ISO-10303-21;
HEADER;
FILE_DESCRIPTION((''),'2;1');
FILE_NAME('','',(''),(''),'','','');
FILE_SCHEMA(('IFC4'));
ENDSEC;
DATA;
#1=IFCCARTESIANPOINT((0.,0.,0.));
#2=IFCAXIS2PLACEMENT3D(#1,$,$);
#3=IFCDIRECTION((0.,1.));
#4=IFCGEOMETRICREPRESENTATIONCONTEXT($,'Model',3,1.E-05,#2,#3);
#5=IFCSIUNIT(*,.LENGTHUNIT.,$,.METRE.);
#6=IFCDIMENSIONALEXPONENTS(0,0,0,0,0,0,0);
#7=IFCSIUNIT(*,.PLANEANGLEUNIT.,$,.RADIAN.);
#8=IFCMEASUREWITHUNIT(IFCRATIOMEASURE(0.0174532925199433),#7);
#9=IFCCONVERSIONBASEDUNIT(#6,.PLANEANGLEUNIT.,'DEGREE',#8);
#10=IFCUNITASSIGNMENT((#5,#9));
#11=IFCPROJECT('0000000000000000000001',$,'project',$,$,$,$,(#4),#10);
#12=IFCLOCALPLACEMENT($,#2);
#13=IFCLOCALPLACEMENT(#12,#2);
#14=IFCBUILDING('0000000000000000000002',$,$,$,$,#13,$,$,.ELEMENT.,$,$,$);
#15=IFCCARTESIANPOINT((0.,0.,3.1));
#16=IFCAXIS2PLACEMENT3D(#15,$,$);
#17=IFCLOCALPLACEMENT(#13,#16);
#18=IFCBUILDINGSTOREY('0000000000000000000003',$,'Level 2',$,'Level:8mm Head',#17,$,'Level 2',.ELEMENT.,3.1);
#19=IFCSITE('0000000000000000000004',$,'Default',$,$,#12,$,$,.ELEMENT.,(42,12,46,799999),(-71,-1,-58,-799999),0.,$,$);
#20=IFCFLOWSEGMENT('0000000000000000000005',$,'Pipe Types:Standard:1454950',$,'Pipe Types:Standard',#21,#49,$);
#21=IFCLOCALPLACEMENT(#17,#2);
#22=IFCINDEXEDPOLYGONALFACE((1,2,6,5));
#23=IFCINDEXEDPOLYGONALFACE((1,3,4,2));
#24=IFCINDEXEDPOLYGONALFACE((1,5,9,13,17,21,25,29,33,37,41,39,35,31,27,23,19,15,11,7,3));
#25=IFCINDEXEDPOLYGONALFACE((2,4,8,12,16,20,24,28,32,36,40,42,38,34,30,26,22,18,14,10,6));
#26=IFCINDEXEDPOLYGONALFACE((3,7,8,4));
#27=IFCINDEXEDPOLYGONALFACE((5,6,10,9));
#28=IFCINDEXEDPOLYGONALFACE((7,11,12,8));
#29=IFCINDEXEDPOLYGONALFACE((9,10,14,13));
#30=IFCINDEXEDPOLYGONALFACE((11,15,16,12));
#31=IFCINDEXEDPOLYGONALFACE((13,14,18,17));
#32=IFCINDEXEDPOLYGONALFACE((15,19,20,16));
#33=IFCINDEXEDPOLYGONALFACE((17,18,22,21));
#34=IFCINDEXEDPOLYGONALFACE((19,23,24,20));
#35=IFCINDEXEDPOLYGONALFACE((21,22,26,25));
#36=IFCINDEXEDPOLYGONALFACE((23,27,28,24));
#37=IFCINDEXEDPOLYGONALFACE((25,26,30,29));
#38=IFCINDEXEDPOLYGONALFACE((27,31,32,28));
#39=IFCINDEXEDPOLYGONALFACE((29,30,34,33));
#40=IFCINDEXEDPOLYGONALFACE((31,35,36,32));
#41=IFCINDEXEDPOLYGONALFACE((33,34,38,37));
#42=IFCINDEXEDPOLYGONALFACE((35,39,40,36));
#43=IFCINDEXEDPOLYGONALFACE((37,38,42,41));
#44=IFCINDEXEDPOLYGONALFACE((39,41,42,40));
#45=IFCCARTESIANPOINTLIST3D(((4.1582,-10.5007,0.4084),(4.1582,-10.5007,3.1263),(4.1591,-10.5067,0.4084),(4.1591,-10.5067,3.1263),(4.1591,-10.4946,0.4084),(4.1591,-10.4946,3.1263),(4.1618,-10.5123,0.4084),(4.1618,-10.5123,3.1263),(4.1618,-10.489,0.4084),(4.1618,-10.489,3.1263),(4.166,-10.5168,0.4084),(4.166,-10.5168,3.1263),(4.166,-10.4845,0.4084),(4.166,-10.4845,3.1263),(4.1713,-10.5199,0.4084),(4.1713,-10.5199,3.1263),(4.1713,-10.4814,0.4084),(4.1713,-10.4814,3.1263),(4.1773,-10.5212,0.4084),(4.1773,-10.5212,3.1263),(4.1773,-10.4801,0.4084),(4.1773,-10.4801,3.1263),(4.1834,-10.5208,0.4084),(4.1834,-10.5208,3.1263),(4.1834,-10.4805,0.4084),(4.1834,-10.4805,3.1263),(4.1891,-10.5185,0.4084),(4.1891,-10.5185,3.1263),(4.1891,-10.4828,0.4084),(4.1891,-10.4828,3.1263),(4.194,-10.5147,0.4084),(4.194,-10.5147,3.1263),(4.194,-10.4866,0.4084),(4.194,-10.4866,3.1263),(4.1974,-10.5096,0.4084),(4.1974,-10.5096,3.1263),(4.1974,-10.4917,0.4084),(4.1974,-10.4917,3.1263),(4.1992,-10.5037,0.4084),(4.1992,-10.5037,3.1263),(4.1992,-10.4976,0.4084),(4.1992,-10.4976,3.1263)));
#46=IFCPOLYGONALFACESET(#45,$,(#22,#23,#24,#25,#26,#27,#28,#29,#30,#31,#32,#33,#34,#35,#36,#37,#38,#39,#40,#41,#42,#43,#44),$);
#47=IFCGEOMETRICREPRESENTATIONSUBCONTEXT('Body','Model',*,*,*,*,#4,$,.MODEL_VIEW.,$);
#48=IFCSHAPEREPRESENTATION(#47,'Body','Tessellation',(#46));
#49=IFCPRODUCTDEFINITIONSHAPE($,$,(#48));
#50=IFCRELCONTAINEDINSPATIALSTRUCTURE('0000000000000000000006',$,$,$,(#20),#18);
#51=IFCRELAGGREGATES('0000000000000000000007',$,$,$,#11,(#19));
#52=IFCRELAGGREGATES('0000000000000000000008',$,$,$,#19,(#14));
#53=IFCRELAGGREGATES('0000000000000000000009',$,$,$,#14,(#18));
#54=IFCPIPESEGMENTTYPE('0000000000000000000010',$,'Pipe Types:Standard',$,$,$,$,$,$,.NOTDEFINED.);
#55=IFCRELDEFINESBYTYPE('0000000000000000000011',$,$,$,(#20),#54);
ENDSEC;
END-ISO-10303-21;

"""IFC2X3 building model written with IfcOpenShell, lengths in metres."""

from ifc_helpers import new_model, entity, si_unit, converted_unit, direction, frame, origin, origin_2d_with_axis, place, context, subcontext, project, spatial, circle, extrude, type_object, element, save


model = new_model("IFC2X3")

# Units and contexts
model_context = context("Model", 3, precision=1e-05, world=origin(), true_north=direction((0.0, 1.0)))
body_context = subcontext(model_context, "Body", "Model", "MODEL_VIEW")
ifc_project = project(units=[si_unit("LENGTHUNIT", "METRE"), converted_unit("PLANEANGLEUNIT", "DEGREE", entity("IfcRatioMeasure", 0.0174532925199433), si_unit("PLANEANGLEUNIT", "RADIAN"), dimensions=[0, 0, 0, 0, 0, 0, 0])], contexts=[model_context])

# Site, building, storey
site_placement = place(None, origin())
site = spatial("IfcSite", under=ifc_project, at=site_placement, Name="Default", CompositionType="ELEMENT", RefLatitude=(42, 12, 46, 799999), RefLongitude=(-71, -1, -58, -799999), RefElevation=0.0)
building_placement = place(site_placement, origin())
building = spatial("IfcBuilding", under=site, at=building_placement, CompositionType="ELEMENT")
storey_placement = place(building_placement, frame((0.0, 0.0, 3.1)))
storey = spatial("IfcBuildingStorey", under=building, at=storey_placement, Name="Level 2", ObjectType="Level:8mm Head", LongName="Level 2", CompositionType="ELEMENT", Elevation=3.1)

# Flow segment
pipe_segment_type = type_object("IfcPipeSegmentType", Name="Pipe Types:Standard", PredefinedType="NOTDEFINED")
flow_segment_1_placement = place(storey_placement, origin())
element("IfcFlowSegment", 1, at=flow_segment_1_placement, inside=storey, type_object=pipe_segment_type, Name="Pipe Types:Standard:1454950", ObjectType="Pipe Types:Standard", context=body_context, shape_type="SweptSolid", body=[
    extrude(circle(Radius=0.0206, at=origin_2d_with_axis()), frame((4.1788, -10.5007, 0.4084), z_axis=(0.0, 0.0, 1.0), x_axis=(-1.0, 0.0, 0.0)), (0.0, 0.0, 1.0), 2.7179),
])

save(model, "model.ifc")
